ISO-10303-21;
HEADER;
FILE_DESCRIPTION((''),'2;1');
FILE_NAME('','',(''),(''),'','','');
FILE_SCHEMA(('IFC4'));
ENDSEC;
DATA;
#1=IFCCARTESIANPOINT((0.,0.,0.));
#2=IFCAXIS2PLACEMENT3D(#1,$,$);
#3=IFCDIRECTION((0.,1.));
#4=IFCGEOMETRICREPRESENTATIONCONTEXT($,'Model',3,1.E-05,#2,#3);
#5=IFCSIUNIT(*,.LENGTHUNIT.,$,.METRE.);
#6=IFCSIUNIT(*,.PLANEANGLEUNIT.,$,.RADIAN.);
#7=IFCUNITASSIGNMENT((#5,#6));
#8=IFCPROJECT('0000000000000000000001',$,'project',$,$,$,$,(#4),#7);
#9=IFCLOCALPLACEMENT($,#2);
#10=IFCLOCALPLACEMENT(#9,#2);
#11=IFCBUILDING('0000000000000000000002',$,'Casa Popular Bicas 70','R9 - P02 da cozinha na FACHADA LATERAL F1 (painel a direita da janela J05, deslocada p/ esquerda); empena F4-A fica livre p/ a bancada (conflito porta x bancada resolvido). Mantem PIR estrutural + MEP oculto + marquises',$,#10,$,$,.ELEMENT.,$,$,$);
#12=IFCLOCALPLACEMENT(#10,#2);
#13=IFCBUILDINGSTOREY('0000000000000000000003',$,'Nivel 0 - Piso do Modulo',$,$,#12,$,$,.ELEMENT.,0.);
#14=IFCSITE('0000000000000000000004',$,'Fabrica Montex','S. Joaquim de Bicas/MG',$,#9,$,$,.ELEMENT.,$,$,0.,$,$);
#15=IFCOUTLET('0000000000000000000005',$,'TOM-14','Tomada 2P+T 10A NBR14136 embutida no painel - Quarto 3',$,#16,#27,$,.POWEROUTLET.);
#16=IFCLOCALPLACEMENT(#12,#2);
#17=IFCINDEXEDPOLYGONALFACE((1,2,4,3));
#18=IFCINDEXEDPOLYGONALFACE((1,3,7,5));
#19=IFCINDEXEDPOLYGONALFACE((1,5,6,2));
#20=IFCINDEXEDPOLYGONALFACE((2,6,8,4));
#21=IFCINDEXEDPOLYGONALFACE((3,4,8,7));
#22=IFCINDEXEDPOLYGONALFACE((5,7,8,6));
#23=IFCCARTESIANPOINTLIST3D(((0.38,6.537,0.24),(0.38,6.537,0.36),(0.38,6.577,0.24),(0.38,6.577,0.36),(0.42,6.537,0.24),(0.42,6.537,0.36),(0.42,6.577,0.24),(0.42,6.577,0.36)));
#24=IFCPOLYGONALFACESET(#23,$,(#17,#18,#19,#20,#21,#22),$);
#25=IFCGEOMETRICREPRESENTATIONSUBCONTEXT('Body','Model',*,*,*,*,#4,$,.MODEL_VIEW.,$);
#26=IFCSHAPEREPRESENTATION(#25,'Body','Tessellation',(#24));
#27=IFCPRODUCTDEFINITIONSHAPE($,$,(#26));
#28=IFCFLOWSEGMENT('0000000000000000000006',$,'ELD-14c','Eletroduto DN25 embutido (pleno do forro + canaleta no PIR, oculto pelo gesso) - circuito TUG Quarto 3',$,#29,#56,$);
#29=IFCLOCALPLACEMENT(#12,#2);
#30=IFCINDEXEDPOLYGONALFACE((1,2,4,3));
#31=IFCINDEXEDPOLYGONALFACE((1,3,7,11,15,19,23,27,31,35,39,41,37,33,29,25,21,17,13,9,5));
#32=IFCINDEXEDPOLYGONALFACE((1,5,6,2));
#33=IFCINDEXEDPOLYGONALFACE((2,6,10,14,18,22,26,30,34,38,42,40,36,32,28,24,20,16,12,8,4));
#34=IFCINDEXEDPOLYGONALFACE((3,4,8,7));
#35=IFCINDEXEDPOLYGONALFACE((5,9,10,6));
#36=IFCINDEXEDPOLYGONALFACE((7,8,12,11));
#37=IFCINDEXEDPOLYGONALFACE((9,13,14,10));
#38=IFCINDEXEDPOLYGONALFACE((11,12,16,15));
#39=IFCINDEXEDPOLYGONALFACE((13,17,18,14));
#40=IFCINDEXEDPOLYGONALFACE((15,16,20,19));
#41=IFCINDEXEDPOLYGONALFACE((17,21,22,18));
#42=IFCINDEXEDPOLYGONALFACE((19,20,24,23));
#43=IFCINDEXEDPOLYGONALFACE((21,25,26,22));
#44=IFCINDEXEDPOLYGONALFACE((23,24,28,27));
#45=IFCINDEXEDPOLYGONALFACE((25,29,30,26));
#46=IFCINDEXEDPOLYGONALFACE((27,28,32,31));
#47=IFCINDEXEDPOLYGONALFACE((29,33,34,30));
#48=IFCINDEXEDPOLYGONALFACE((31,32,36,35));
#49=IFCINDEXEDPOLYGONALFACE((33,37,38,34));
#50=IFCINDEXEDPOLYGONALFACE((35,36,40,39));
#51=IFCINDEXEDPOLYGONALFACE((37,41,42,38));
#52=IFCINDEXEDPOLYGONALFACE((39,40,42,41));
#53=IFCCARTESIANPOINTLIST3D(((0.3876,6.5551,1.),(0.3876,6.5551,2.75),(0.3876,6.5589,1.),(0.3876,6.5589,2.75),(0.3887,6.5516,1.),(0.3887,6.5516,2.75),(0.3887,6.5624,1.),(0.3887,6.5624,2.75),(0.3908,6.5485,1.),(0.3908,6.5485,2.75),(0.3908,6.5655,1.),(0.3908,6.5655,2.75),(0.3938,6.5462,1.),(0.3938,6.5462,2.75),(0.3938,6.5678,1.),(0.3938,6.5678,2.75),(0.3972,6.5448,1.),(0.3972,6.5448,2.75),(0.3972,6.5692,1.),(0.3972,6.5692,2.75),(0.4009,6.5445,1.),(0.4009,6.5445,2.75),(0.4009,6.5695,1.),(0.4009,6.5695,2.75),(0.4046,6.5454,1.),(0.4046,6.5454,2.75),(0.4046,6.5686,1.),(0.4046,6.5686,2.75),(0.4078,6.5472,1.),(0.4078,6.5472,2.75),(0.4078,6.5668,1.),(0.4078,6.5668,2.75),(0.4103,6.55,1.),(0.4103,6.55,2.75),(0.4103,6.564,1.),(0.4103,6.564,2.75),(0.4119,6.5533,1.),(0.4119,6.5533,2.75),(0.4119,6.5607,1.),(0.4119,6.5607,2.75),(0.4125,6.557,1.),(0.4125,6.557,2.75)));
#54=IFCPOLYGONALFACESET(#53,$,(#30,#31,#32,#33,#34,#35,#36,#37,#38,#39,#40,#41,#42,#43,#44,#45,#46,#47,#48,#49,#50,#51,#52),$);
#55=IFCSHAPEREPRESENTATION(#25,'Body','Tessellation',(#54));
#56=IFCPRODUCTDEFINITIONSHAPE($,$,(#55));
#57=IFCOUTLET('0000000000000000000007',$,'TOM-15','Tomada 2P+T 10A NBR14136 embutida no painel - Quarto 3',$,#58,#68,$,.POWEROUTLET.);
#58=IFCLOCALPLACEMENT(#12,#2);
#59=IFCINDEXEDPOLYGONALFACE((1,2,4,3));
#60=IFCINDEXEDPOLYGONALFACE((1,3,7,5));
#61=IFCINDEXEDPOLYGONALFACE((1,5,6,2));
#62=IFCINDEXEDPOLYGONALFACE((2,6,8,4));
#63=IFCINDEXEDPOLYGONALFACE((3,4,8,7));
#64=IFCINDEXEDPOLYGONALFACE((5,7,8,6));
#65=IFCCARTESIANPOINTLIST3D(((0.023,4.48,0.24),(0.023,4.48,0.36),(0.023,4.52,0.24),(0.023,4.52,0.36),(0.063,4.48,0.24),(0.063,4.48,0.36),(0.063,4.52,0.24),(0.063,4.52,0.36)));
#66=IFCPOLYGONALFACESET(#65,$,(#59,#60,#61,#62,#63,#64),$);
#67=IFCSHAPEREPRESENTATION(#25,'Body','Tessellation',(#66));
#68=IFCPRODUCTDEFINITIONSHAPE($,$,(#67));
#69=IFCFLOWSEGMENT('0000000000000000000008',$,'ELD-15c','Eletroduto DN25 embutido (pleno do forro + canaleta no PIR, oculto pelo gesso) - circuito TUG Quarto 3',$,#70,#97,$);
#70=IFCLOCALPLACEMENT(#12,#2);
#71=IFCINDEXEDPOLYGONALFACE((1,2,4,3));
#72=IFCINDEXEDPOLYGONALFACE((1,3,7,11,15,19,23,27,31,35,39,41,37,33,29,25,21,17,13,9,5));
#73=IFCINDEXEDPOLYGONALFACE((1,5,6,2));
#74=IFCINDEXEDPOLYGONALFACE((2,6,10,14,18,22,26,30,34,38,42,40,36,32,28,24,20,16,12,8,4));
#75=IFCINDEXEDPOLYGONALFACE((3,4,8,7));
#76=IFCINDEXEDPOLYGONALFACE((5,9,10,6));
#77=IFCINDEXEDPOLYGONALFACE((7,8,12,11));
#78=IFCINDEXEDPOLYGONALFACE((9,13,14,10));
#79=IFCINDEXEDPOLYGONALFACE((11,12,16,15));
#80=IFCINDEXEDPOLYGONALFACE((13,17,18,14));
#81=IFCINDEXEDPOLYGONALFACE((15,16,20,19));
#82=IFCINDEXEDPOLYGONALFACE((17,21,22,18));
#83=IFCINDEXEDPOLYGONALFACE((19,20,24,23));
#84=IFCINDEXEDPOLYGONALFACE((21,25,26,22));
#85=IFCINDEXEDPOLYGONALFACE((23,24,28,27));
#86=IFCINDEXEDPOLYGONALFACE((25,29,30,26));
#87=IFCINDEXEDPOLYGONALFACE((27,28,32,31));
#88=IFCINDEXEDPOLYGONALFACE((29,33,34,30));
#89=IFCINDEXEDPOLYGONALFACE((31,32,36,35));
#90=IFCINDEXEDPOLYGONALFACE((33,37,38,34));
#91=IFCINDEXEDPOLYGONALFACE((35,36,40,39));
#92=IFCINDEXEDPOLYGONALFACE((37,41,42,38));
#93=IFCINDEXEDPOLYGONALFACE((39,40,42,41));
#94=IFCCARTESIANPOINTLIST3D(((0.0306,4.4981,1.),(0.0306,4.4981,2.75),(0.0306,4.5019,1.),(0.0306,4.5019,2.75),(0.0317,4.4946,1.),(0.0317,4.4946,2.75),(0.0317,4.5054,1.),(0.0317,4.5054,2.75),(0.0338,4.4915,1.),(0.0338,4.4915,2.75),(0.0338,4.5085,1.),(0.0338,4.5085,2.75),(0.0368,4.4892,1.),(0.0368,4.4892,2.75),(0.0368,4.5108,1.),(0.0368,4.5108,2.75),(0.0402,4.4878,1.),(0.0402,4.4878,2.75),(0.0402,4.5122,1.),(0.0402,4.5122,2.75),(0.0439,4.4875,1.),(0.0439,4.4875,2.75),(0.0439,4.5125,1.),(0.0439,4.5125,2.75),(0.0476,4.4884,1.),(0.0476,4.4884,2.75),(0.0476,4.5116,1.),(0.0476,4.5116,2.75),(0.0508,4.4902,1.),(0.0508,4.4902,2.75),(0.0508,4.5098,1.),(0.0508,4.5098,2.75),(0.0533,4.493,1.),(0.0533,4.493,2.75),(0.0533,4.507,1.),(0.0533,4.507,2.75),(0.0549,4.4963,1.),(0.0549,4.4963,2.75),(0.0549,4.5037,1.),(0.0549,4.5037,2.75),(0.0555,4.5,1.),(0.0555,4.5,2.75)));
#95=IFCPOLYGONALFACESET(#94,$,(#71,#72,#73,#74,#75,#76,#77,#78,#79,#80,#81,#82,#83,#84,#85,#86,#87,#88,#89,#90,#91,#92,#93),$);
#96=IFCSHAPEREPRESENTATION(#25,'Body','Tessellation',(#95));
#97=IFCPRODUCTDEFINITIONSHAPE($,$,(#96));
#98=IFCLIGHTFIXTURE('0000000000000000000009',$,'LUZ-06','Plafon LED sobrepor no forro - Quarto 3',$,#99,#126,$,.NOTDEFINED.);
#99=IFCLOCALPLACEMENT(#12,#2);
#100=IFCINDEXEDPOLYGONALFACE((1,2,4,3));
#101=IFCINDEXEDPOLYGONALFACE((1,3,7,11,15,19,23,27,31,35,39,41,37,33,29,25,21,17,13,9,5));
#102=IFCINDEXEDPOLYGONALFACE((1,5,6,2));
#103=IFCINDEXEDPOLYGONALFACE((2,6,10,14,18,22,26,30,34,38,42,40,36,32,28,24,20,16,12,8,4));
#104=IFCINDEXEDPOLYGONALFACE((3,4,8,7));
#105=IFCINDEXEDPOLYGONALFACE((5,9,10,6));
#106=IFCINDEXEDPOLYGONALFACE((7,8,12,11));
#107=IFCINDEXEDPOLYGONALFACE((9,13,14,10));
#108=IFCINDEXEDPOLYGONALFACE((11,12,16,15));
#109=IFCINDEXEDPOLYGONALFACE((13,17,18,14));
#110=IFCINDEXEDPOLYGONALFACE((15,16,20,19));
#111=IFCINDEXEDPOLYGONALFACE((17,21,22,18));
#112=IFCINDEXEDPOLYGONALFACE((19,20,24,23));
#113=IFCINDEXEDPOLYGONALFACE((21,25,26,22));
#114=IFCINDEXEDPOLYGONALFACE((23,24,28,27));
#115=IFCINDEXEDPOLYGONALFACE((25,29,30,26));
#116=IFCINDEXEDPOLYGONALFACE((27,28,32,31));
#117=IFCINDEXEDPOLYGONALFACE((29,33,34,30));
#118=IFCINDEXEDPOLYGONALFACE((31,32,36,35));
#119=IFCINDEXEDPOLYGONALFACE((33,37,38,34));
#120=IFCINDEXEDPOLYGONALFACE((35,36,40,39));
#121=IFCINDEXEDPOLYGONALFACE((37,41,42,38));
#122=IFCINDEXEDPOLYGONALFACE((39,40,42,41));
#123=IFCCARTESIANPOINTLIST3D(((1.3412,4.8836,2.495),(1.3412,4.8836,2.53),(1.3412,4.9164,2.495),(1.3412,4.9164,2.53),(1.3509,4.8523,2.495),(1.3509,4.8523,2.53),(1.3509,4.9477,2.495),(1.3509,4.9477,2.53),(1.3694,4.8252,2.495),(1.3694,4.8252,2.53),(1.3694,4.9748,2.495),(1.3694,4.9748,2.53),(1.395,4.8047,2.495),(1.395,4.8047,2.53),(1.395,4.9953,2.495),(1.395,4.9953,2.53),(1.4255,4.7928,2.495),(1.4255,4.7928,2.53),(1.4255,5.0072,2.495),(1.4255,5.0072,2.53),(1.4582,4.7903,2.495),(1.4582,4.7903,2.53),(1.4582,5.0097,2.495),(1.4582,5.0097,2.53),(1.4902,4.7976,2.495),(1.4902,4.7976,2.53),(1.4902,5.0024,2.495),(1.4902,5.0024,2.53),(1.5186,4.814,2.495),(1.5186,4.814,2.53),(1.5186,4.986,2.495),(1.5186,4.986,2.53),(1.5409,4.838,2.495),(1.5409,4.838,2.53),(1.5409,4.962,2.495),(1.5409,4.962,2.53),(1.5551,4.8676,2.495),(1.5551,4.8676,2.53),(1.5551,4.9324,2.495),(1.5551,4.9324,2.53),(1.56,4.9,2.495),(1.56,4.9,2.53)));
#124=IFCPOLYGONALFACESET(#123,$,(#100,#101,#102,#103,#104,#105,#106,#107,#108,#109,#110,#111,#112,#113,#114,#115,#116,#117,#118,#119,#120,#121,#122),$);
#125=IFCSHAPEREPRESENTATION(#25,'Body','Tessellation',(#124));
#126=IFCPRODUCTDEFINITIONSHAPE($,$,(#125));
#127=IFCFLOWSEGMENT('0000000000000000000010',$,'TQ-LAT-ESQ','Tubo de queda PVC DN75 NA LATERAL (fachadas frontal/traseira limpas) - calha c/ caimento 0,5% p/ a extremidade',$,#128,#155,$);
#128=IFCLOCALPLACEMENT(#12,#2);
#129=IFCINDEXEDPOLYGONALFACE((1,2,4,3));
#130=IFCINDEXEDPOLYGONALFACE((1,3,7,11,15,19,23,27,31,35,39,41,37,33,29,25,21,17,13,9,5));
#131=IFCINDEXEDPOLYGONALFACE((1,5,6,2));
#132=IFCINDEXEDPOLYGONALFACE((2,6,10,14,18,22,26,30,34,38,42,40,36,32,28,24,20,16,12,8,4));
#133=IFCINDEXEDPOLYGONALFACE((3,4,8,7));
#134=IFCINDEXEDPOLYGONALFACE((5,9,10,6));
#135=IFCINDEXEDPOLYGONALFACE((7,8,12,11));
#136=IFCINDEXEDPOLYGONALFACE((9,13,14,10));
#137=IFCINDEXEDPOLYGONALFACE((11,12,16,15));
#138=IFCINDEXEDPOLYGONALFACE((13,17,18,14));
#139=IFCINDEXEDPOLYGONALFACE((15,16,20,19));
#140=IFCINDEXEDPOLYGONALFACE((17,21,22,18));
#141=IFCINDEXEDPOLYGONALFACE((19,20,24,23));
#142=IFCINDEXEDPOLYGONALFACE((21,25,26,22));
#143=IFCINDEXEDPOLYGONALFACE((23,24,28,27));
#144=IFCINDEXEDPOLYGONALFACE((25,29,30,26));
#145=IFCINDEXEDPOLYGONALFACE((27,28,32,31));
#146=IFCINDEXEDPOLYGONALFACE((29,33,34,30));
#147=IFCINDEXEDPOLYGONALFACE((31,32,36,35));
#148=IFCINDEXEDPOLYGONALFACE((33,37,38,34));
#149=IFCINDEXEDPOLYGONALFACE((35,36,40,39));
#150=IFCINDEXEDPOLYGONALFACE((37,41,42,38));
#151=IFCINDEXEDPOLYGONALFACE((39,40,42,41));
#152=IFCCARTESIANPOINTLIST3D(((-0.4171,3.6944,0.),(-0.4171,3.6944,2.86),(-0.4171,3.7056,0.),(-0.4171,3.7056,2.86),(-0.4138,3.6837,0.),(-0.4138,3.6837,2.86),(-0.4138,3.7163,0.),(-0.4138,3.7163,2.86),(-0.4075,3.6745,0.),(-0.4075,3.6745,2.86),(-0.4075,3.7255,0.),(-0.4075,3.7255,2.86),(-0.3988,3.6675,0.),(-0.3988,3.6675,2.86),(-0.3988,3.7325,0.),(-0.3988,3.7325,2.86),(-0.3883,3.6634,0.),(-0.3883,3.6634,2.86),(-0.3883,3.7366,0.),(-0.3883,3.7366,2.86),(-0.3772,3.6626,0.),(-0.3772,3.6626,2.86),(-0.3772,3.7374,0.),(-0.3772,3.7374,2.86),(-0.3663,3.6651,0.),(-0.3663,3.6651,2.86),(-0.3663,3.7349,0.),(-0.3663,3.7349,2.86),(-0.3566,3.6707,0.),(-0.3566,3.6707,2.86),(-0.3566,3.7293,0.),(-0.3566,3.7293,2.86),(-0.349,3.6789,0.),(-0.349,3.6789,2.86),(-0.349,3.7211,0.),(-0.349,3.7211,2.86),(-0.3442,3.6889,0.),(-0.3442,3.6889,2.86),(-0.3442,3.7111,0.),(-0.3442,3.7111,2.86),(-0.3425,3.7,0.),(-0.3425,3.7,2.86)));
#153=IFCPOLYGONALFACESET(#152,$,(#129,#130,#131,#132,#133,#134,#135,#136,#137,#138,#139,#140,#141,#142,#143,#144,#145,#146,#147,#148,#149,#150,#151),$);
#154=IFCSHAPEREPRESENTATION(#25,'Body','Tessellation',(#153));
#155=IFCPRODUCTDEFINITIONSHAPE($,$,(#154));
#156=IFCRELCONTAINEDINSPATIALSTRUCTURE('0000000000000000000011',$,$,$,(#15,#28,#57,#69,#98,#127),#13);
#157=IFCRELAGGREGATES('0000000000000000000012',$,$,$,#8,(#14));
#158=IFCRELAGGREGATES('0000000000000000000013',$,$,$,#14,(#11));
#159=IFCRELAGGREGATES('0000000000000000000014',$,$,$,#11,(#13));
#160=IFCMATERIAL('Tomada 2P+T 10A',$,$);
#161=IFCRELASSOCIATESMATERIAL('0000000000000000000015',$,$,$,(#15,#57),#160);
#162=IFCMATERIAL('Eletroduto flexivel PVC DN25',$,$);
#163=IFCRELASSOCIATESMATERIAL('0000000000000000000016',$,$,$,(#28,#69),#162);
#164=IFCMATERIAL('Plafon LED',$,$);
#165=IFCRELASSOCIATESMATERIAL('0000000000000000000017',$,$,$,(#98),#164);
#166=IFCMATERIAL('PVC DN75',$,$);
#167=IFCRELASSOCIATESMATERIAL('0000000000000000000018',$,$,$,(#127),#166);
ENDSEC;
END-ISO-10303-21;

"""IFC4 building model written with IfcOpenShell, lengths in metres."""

from ifc_helpers import new_model, si_unit, direction, frame, frame_2d, origin, origin_2d, place, context, subcontext, project, spatial, rectangle, circle, extrude, material, element, save


model = new_model("IFC4")

# Units and contexts
model_context = context("Model", 3, precision=1e-05, world=origin(), true_north=direction((0.0, 1.0)))
body_context = subcontext(model_context, "Body", "Model", "MODEL_VIEW")
ifc_project = project(units=[si_unit("LENGTHUNIT", "METRE"), si_unit("PLANEANGLEUNIT", "RADIAN")], contexts=[model_context])

# Site, building, storey
site_placement = place(None, origin())
site = spatial("IfcSite", under=ifc_project, at=site_placement, Name="Fabrica Montex", Description="S. Joaquim de Bicas/MG", CompositionType="ELEMENT", RefElevation=0.0)
building_placement = place(site_placement, origin())
building = spatial("IfcBuilding", under=site, at=building_placement, Name="Casa Popular Bicas 70", Description="R9 - P02 da cozinha na FACHADA LATERAL F1 (painel a direita da janela J05, deslocada p/ esquerda); empena F4-A fica livre p/ a bancada (conflito porta x bancada resolvido). Mantem PIR estrutural + MEP oculto + marquises", CompositionType="ELEMENT")
storey_placement = place(building_placement, origin())
storey = spatial("IfcBuildingStorey", under=building, at=storey_placement, Name="Nivel 0 - Piso do Modulo", CompositionType="ELEMENT", Elevation=0.0)

# Outlet
ifc_material_1 = material(Name="Tomada 2P+T 10A")
outlet_1_placement = place(storey_placement, frame((0.38, 6.537, 0.24)))
element("IfcOutlet", 1, at=outlet_1_placement, inside=storey, material=ifc_material_1, Name="TOM-14", Description="Tomada 2P+T 10A NBR14136 embutida no painel - Quarto 3", PredefinedType="POWEROUTLET", context=body_context, shape_type="SweptSolid", body=[
    extrude(rectangle(XDim=0.04, YDim=0.04, at=frame_2d((0.02, 0.02))), origin(), (0.0, 0.0, 1.0), 0.12),
])

# Flow segment
ifc_material_2 = material(Name="Eletroduto flexivel PVC DN25")
flow_segment_1_placement = place(storey_placement, frame((0.4, 6.557, 2.75), z_axis=(0.0, 0.0, -1.0), x_axis=(1.0, 0.0, 0.0)))
element("IfcFlowSegment", 2, at=flow_segment_1_placement, inside=storey, material=ifc_material_2, Name="ELD-14c", Description="Eletroduto DN25 embutido (pleno do forro + canaleta no PIR, oculto pelo gesso) - circuito TUG Quarto 3", context=body_context, shape_type="SweptSolid", body=[
    extrude(circle(Radius=0.0125, at=origin_2d()), origin(), (0.0, 0.0, 1.0), 1.75),
])

# Outlet
outlet_2_placement = place(storey_placement, frame((0.023, 4.48, 0.24)))
element("IfcOutlet", 3, at=outlet_2_placement, inside=storey, material=ifc_material_1, Name="TOM-15", Description="Tomada 2P+T 10A NBR14136 embutida no painel - Quarto 3", PredefinedType="POWEROUTLET", context=body_context, shape_type="SweptSolid", body=[
    extrude(rectangle(XDim=0.04, YDim=0.04, at=frame_2d((0.02, 0.02))), origin(), (0.0, 0.0, 1.0), 0.12),
])

# Flow segment
flow_segment_2_placement = place(storey_placement, frame((0.043, 4.5, 2.75), z_axis=(0.0, 0.0, -1.0), x_axis=(1.0, 0.0, 0.0)))
element("IfcFlowSegment", 4, at=flow_segment_2_placement, inside=storey, material=ifc_material_2, Name="ELD-15c", Description="Eletroduto DN25 embutido (pleno do forro + canaleta no PIR, oculto pelo gesso) - circuito TUG Quarto 3", context=body_context, shape_type="SweptSolid", body=[
    extrude(circle(Radius=0.0125, at=origin_2d()), origin(), (0.0, 0.0, 1.0), 1.75),
])

# Light fixture
ifc_material_3 = material(Name="Plafon LED")
light_fixture_placement = place(storey_placement, frame((1.45, 4.9, 2.495)))
element("IfcLightFixture", 5, at=light_fixture_placement, inside=storey, material=ifc_material_3, Name="LUZ-06", Description="Plafon LED sobrepor no forro - Quarto 3", PredefinedType="NOTDEFINED", context=body_context, shape_type="SweptSolid", body=[
    extrude(circle(Radius=0.11, at=origin_2d()), origin(), (0.0, 0.0, 1.0), 0.035),
])

# Flow segment
ifc_material_4 = material(Name="PVC DN75")
flow_segment_3_placement = place(storey_placement, frame((-0.38, 3.7, 0.0)))
element("IfcFlowSegment", 6, at=flow_segment_3_placement, inside=storey, material=ifc_material_4, Name="TQ-LAT-ESQ", Description="Tubo de queda PVC DN75 NA LATERAL (fachadas frontal/traseira limpas) - calha c/ caimento 0,5% p/ a extremidade", context=body_context, shape_type="SweptSolid", body=[
    extrude(circle(Radius=0.0375, at=origin_2d()), origin(), (0.0, 0.0, 1.0), 2.86),
])

save(model, "model.ifc")
